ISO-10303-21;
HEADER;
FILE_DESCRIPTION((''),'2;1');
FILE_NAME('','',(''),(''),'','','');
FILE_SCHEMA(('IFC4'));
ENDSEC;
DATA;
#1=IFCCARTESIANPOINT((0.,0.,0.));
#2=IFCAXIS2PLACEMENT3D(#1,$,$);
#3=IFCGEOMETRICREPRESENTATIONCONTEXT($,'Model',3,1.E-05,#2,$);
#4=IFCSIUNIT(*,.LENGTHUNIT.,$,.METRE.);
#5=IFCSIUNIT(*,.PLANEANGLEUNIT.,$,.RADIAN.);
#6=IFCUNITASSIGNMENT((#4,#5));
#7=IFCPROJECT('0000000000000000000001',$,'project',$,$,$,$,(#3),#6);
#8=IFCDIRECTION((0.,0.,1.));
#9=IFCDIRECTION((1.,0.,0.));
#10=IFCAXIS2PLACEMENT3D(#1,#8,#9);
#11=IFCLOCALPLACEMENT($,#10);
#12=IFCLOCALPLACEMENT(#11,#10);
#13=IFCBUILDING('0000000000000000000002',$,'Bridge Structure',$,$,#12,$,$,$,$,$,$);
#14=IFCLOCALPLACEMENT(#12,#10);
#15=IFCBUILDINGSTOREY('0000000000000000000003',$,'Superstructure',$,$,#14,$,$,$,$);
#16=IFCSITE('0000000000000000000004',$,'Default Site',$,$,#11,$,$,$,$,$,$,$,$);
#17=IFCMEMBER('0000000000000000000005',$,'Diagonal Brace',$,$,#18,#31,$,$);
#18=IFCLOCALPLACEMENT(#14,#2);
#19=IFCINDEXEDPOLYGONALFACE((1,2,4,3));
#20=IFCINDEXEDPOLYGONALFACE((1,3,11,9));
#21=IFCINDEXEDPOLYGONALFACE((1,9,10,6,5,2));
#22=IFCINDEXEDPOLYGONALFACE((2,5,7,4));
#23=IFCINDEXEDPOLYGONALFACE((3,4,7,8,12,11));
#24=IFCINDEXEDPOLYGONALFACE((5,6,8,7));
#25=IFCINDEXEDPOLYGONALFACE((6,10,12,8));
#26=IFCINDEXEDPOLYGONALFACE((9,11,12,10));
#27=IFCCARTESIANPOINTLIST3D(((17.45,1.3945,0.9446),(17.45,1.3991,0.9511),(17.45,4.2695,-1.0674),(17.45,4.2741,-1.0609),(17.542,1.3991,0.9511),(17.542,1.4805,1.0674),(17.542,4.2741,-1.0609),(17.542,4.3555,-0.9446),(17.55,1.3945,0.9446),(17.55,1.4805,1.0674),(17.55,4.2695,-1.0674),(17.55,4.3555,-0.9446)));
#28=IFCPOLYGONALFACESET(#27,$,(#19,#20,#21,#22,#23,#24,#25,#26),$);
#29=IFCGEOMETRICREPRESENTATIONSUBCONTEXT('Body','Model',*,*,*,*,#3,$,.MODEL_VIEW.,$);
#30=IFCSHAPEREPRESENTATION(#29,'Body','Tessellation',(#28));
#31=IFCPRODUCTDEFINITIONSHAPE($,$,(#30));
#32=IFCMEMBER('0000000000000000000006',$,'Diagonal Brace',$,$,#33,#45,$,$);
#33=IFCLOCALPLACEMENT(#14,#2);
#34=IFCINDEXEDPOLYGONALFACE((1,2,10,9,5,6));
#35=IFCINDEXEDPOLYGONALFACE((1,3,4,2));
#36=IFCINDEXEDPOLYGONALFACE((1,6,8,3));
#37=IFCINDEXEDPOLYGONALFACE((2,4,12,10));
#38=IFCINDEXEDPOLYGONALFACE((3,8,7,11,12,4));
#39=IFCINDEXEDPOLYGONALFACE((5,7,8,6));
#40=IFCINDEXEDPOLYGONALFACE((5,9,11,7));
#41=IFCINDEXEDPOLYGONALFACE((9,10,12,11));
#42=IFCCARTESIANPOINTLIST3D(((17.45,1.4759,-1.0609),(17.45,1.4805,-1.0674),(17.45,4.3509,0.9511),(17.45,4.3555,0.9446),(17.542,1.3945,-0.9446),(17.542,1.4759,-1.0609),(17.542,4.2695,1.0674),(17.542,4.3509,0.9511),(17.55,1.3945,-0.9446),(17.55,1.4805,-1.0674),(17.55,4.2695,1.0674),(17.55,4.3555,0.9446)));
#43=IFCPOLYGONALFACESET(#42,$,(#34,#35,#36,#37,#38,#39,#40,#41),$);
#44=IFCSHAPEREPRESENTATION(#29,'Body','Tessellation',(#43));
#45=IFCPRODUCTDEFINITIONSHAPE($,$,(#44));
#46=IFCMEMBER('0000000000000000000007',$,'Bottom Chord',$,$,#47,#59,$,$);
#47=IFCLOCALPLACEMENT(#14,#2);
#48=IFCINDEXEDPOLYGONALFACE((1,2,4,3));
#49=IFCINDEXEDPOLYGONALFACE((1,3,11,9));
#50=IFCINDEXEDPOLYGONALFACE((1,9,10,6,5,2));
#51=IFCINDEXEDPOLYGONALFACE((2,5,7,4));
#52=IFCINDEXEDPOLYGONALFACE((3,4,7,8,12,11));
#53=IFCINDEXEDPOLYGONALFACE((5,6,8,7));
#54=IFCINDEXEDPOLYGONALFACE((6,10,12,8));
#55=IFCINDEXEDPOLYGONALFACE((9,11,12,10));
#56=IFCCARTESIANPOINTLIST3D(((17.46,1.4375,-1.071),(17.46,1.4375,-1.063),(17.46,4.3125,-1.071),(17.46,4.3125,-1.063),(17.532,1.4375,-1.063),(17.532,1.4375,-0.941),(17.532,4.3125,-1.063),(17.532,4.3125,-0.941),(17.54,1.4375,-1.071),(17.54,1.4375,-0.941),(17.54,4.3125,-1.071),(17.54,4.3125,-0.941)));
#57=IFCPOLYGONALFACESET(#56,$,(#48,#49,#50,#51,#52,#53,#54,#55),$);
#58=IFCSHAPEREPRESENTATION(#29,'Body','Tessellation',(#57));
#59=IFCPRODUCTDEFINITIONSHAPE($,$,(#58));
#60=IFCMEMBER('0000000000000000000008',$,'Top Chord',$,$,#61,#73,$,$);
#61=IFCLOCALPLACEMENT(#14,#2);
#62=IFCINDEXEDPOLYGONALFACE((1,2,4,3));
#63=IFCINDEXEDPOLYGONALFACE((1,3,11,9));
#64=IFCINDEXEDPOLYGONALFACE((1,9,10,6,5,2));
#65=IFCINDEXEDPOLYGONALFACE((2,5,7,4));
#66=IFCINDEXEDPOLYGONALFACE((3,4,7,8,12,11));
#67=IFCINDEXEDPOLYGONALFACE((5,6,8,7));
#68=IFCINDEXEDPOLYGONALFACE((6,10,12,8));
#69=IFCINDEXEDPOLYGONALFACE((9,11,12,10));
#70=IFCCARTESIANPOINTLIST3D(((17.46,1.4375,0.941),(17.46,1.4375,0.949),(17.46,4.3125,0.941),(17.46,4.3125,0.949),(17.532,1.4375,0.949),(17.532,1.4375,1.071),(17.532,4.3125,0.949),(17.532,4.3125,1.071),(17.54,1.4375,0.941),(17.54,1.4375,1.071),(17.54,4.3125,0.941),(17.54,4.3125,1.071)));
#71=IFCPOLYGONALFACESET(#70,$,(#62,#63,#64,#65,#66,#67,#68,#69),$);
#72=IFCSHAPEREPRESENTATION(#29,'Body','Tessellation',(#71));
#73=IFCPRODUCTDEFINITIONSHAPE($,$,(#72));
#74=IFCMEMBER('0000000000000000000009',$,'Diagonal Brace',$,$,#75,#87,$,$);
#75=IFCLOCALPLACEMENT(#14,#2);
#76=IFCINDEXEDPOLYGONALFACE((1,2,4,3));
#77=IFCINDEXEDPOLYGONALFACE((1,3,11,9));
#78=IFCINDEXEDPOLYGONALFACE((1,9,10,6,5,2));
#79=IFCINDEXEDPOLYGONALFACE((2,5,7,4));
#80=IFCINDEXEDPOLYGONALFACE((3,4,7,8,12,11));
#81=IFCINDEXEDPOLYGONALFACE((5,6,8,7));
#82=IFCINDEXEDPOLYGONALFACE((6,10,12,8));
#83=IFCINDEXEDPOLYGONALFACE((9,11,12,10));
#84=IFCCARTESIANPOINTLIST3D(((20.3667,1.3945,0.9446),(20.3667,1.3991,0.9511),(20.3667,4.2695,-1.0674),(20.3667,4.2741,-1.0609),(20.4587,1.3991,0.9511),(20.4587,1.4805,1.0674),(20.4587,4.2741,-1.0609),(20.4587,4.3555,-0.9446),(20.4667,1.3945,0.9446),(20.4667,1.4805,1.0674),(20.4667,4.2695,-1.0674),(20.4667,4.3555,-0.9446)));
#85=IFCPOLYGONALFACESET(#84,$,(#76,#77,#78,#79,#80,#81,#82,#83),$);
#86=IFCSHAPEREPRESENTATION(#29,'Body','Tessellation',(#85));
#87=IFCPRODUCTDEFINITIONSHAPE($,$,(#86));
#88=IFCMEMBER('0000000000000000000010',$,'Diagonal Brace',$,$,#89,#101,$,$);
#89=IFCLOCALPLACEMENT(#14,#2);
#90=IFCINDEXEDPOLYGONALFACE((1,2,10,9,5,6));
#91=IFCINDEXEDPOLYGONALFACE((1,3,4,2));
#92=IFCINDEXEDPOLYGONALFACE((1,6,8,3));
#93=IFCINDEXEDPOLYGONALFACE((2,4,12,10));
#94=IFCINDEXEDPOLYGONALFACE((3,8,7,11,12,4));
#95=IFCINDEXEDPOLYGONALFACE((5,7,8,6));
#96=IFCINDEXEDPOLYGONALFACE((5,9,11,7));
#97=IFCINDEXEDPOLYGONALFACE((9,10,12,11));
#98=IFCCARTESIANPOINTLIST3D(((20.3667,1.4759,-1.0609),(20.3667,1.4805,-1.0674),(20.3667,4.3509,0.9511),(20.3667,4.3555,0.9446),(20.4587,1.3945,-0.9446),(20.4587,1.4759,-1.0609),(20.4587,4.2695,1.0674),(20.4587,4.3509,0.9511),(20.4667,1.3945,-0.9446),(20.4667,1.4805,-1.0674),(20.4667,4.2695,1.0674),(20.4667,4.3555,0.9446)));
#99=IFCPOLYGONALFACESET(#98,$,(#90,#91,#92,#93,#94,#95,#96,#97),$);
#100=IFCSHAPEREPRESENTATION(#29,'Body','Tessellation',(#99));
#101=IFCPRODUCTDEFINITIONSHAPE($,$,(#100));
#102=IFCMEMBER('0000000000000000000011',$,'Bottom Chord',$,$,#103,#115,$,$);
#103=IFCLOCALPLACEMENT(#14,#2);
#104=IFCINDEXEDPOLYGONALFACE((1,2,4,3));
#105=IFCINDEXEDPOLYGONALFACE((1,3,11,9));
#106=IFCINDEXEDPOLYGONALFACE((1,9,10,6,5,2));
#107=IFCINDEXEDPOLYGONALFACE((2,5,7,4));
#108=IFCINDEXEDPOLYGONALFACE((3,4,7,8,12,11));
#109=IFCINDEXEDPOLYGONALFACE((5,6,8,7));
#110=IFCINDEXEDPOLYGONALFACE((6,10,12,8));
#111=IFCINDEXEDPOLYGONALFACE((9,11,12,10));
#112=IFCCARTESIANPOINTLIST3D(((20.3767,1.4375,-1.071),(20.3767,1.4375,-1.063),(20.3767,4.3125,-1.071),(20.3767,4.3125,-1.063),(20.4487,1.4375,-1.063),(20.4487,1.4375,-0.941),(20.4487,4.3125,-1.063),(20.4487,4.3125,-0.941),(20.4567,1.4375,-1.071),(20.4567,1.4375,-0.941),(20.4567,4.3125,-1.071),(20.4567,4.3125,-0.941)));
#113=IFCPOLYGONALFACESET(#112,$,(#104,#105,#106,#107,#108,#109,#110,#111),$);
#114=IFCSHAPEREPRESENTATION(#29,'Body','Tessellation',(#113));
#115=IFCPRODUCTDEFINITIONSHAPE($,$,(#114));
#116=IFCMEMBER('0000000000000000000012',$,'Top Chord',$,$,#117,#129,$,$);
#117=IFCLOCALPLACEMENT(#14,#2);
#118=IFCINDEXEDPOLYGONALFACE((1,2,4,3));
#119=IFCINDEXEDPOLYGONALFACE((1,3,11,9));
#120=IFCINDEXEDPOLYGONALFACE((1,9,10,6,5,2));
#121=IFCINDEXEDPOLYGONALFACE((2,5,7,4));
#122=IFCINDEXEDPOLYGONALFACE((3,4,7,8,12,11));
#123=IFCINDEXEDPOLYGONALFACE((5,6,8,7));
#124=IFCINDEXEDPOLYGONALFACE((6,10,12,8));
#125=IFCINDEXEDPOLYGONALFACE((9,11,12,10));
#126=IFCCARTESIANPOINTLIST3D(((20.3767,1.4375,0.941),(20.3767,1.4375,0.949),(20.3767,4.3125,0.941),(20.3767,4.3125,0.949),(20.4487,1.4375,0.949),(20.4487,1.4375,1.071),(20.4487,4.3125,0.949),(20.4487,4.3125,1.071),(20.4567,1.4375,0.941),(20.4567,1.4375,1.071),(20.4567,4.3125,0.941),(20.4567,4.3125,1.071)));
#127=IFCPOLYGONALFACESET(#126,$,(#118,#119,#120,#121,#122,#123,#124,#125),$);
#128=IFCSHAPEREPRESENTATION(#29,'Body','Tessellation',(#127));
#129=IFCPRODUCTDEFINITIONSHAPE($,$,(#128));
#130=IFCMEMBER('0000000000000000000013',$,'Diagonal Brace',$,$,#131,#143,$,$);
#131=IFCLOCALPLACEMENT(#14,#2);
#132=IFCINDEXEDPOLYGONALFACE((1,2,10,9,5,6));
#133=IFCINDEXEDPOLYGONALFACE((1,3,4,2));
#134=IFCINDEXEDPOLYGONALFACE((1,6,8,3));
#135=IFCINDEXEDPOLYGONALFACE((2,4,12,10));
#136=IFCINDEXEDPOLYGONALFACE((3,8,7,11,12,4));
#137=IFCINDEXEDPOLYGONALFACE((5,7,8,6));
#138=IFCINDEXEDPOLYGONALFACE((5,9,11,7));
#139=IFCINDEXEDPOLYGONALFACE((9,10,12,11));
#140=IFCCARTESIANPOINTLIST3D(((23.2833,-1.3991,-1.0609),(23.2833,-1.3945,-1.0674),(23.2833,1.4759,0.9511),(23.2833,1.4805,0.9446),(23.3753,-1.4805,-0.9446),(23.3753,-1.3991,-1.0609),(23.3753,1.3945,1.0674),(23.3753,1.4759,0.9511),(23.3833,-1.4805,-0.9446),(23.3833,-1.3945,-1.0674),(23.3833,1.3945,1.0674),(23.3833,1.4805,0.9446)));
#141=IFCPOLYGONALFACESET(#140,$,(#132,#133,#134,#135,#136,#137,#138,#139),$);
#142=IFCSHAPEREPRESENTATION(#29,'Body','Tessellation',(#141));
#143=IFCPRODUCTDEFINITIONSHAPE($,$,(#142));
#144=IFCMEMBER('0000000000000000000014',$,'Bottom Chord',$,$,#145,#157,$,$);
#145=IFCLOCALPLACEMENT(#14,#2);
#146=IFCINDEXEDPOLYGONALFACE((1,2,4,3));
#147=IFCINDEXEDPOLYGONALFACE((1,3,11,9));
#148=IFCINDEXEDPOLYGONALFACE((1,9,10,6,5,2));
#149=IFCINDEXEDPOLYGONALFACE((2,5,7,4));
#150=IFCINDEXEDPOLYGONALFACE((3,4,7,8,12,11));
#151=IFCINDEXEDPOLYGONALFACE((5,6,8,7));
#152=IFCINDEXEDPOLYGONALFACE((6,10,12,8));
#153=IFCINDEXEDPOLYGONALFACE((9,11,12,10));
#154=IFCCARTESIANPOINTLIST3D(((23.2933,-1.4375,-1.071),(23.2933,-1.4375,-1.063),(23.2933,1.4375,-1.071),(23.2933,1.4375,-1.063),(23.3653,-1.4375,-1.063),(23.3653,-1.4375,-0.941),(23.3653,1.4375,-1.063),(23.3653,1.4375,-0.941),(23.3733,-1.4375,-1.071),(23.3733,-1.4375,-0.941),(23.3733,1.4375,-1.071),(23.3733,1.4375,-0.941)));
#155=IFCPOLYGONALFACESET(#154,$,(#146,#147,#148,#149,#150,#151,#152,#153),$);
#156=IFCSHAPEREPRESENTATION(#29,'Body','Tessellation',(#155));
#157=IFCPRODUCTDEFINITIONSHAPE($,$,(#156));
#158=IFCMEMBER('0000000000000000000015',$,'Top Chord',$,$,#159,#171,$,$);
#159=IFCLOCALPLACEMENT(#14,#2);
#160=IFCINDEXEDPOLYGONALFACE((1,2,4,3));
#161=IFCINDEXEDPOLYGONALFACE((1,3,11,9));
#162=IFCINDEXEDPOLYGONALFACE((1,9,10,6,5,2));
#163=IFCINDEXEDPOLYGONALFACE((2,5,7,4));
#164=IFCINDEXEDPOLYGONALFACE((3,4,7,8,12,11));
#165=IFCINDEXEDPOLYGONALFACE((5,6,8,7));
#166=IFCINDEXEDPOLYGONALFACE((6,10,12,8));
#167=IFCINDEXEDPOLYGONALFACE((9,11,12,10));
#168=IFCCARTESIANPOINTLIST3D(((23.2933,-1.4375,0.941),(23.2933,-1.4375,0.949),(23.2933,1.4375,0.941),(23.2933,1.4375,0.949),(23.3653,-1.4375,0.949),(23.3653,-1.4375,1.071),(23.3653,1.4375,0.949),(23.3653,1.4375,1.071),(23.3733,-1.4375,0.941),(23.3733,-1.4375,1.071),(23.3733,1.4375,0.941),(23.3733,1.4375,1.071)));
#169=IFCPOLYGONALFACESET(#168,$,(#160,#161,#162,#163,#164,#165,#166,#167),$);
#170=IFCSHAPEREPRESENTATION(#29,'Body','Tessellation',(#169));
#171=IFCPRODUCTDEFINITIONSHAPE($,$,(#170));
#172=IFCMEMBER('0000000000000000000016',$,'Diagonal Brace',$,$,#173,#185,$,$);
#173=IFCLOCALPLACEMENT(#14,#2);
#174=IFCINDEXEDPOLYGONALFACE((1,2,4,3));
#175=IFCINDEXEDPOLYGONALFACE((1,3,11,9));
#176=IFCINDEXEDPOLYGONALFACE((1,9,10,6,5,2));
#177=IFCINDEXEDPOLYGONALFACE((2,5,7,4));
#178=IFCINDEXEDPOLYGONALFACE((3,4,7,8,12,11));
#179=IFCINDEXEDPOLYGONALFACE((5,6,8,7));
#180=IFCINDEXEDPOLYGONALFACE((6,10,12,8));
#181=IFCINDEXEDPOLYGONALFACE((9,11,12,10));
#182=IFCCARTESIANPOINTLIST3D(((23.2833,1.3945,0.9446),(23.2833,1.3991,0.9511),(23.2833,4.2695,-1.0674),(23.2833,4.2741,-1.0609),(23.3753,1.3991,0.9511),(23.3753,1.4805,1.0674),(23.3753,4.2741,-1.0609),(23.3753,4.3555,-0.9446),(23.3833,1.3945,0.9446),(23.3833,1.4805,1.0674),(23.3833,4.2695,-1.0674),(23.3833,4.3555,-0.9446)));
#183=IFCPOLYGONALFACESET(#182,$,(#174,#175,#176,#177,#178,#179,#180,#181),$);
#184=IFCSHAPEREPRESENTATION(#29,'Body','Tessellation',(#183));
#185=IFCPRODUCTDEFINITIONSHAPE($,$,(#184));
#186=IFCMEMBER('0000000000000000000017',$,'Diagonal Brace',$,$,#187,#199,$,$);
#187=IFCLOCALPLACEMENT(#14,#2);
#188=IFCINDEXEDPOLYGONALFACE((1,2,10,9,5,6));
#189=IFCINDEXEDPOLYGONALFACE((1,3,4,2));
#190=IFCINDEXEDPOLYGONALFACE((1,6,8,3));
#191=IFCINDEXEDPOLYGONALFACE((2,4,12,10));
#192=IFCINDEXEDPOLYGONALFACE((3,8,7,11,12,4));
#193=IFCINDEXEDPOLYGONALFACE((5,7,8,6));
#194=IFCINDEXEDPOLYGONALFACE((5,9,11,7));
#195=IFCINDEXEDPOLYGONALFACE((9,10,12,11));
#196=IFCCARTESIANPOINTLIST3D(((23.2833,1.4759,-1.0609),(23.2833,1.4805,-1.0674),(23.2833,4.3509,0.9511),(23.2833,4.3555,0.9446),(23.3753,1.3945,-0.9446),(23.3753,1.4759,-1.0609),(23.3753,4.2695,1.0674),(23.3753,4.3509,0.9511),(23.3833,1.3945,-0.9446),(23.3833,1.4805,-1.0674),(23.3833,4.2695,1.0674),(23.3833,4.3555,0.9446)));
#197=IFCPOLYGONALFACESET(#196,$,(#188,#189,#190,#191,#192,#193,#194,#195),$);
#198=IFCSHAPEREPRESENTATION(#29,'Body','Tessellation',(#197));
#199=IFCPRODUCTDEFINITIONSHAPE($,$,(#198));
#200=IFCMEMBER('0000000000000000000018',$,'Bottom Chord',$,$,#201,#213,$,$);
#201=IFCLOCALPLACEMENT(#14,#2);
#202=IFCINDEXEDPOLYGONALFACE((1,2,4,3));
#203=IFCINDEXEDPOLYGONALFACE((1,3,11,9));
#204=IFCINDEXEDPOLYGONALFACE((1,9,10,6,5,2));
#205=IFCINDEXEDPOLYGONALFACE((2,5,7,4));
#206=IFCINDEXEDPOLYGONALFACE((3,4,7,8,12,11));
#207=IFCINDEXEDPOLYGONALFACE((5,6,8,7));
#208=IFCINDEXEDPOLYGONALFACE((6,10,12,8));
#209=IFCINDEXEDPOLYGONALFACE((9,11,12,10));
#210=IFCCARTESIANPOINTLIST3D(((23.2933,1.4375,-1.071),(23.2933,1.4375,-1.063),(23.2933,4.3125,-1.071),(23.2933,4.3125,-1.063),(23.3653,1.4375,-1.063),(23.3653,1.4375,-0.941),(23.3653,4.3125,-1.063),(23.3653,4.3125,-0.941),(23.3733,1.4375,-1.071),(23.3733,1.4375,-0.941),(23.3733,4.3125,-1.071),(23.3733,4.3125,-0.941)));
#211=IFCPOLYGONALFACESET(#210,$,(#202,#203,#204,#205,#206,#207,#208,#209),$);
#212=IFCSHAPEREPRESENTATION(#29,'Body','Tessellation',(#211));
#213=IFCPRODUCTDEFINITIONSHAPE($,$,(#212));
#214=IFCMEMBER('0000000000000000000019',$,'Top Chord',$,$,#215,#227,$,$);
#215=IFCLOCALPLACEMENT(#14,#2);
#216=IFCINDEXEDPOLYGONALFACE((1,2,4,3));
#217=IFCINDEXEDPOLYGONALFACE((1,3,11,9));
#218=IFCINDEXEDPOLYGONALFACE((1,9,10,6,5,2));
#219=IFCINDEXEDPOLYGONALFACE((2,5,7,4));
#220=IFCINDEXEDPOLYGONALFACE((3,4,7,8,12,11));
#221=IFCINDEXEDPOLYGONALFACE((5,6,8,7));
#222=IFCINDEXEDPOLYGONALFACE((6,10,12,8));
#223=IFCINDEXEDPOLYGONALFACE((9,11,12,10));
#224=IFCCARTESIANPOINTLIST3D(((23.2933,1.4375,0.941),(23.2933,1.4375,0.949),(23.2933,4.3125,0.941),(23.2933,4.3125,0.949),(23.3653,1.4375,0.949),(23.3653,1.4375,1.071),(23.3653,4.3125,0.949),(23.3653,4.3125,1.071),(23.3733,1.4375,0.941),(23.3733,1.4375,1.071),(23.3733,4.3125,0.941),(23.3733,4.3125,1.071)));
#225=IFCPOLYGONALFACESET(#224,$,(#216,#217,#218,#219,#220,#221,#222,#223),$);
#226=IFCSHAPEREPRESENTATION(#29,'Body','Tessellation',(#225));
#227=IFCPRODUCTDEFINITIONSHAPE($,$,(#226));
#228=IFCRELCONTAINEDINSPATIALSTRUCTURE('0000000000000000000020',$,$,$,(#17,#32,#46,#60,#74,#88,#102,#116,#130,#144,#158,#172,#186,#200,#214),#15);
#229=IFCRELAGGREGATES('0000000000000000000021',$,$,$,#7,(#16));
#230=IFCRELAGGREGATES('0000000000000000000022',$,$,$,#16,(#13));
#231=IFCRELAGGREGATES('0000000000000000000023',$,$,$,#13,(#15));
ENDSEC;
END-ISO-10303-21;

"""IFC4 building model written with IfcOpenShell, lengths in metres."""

from ifc_helpers import new_model, si_unit, frame, origin, origin_with_axes, origin_2d_with_axis, place, context, subcontext, project, spatial, l_section, extrude, element, save


model = new_model("IFC4")

# Units and contexts
model_context = context("Model", 3, precision=1e-05, world=origin())
body_context = subcontext(model_context, "Body", "Model", "MODEL_VIEW")
ifc_project = project(units=[si_unit("LENGTHUNIT", "METRE"), si_unit("PLANEANGLEUNIT", "RADIAN")], contexts=[model_context])

# Site, building, storey
site_placement = place(None, origin_with_axes())
site = spatial("IfcSite", under=ifc_project, at=site_placement, Name="Default Site")
building_placement = place(site_placement, origin_with_axes())
building = spatial("IfcBuilding", under=site, at=building_placement, Name="Bridge Structure")
storey_placement = place(building_placement, origin_with_axes())
storey = spatial("IfcBuildingStorey", under=building, at=storey_placement, Name="Superstructure")

# Members
for number, where, z_axis, x_axis, name in (
    (1, (17.5, 1.4375, 1.006), (0.0, 0.819299, -0.573367), (-1.0, 0.0, 0.0), "Diagonal Brace"),
    (2, (17.5, 1.4375, -1.006), (0.0, 0.819299, 0.573367), (-1.0, 0.0, 0.0), "Diagonal Brace"),
):
    element("IfcMember", number, at=place(storey_placement, frame(where, z_axis=z_axis, x_axis=x_axis)), inside=storey, Name=name, context=body_context, shape_type="SweptSolid", body=[
        extrude(l_section(Depth=0.15, Width=0.1, Thickness=0.008, at=origin_2d_with_axis()), origin_with_axes(), (0.0, 0.0, 1.0), 3.5091),
    ])
for number, where, z_axis, x_axis, name in (
    (3, (17.5, 1.4375, -1.006), (0.0, 1.0, 0.0), (-1.0, 0.0, 0.0), "Bottom Chord"),
    (4, (17.5, 1.4375, 1.006), (0.0, 1.0, 0.0), (-1.0, 0.0, 0.0), "Top Chord"),
):
    element("IfcMember", number, at=place(storey_placement, frame(where, z_axis=z_axis, x_axis=x_axis)), inside=storey, Name=name, context=body_context, shape_type="SweptSolid", body=[
        extrude(l_section(Depth=0.13, Width=0.08, Thickness=0.008, at=origin_2d_with_axis()), origin_with_axes(), (0.0, 0.0, 1.0), 2.875),
    ])
for number, where, z_axis, x_axis, name in (
    (5, (20.4167, 1.4375, 1.006), (0.0, 0.819299, -0.573367), (-1.0, 0.0, 0.0), "Diagonal Brace"),
    (6, (20.4167, 1.4375, -1.006), (0.0, 0.819299, 0.573367), (-1.0, 0.0, 0.0), "Diagonal Brace"),
):
    element("IfcMember", number, at=place(storey_placement, frame(where, z_axis=z_axis, x_axis=x_axis)), inside=storey, Name=name, context=body_context, shape_type="SweptSolid", body=[
        extrude(l_section(Depth=0.15, Width=0.1, Thickness=0.008, at=origin_2d_with_axis()), origin_with_axes(), (0.0, 0.0, 1.0), 3.5091),
    ])
for number, where, z_axis, x_axis, name in (
    (7, (20.4167, 1.4375, -1.006), (0.0, 1.0, 0.0), (-1.0, 0.0, 0.0), "Bottom Chord"),
    (8, (20.4167, 1.4375, 1.006), (0.0, 1.0, 0.0), (-1.0, 0.0, 0.0), "Top Chord"),
):
    element("IfcMember", number, at=place(storey_placement, frame(where, z_axis=z_axis, x_axis=x_axis)), inside=storey, Name=name, context=body_context, shape_type="SweptSolid", body=[
        extrude(l_section(Depth=0.13, Width=0.08, Thickness=0.008, at=origin_2d_with_axis()), origin_with_axes(), (0.0, 0.0, 1.0), 2.875),
    ])
member_placement = place(storey_placement, frame((23.3333, -1.4375, -1.006), z_axis=(0.0, 0.819299, 0.573367), x_axis=(-1.0, 0.0, 0.0)))
element("IfcMember", 9, at=member_placement, inside=storey, Name="Diagonal Brace", context=body_context, shape_type="SweptSolid", body=[
    extrude(l_section(Depth=0.15, Width=0.1, Thickness=0.008, at=origin_2d_with_axis()), origin_with_axes(), (0.0, 0.0, 1.0), 3.5091),
])
for number, where, z_axis, x_axis, name in (
    (10, (23.3333, -1.4375, -1.006), (0.0, 1.0, 0.0), (-1.0, 0.0, 0.0), "Bottom Chord"),
    (11, (23.3333, -1.4375, 1.006), (0.0, 1.0, 0.0), (-1.0, 0.0, 0.0), "Top Chord"),
):
    element("IfcMember", number, at=place(storey_placement, frame(where, z_axis=z_axis, x_axis=x_axis)), inside=storey, Name=name, context=body_context, shape_type="SweptSolid", body=[
        extrude(l_section(Depth=0.13, Width=0.08, Thickness=0.008, at=origin_2d_with_axis()), origin_with_axes(), (0.0, 0.0, 1.0), 2.875),
    ])
for number, where, z_axis, x_axis, name in (
    (12, (23.3333, 1.4375, 1.006), (0.0, 0.819299, -0.573367), (-1.0, 0.0, 0.0), "Diagonal Brace"),
    (13, (23.3333, 1.4375, -1.006), (0.0, 0.819299, 0.573367), (-1.0, 0.0, 0.0), "Diagonal Brace"),
):
    element("IfcMember", number, at=place(storey_placement, frame(where, z_axis=z_axis, x_axis=x_axis)), inside=storey, Name=name, context=body_context, shape_type="SweptSolid", body=[
        extrude(l_section(Depth=0.15, Width=0.1, Thickness=0.008, at=origin_2d_with_axis()), origin_with_axes(), (0.0, 0.0, 1.0), 3.5091),
    ])
for number, where, z_axis, x_axis, name in (
    (14, (23.3333, 1.4375, -1.006), (0.0, 1.0, 0.0), (-1.0, 0.0, 0.0), "Bottom Chord"),
    (15, (23.3333, 1.4375, 1.006), (0.0, 1.0, 0.0), (-1.0, 0.0, 0.0), "Top Chord"),
):
    element("IfcMember", number, at=place(storey_placement, frame(where, z_axis=z_axis, x_axis=x_axis)), inside=storey, Name=name, context=body_context, shape_type="SweptSolid", body=[
        extrude(l_section(Depth=0.13, Width=0.08, Thickness=0.008, at=origin_2d_with_axis()), origin_with_axes(), (0.0, 0.0, 1.0), 2.875),
    ])

save(model, "model.ifc")
